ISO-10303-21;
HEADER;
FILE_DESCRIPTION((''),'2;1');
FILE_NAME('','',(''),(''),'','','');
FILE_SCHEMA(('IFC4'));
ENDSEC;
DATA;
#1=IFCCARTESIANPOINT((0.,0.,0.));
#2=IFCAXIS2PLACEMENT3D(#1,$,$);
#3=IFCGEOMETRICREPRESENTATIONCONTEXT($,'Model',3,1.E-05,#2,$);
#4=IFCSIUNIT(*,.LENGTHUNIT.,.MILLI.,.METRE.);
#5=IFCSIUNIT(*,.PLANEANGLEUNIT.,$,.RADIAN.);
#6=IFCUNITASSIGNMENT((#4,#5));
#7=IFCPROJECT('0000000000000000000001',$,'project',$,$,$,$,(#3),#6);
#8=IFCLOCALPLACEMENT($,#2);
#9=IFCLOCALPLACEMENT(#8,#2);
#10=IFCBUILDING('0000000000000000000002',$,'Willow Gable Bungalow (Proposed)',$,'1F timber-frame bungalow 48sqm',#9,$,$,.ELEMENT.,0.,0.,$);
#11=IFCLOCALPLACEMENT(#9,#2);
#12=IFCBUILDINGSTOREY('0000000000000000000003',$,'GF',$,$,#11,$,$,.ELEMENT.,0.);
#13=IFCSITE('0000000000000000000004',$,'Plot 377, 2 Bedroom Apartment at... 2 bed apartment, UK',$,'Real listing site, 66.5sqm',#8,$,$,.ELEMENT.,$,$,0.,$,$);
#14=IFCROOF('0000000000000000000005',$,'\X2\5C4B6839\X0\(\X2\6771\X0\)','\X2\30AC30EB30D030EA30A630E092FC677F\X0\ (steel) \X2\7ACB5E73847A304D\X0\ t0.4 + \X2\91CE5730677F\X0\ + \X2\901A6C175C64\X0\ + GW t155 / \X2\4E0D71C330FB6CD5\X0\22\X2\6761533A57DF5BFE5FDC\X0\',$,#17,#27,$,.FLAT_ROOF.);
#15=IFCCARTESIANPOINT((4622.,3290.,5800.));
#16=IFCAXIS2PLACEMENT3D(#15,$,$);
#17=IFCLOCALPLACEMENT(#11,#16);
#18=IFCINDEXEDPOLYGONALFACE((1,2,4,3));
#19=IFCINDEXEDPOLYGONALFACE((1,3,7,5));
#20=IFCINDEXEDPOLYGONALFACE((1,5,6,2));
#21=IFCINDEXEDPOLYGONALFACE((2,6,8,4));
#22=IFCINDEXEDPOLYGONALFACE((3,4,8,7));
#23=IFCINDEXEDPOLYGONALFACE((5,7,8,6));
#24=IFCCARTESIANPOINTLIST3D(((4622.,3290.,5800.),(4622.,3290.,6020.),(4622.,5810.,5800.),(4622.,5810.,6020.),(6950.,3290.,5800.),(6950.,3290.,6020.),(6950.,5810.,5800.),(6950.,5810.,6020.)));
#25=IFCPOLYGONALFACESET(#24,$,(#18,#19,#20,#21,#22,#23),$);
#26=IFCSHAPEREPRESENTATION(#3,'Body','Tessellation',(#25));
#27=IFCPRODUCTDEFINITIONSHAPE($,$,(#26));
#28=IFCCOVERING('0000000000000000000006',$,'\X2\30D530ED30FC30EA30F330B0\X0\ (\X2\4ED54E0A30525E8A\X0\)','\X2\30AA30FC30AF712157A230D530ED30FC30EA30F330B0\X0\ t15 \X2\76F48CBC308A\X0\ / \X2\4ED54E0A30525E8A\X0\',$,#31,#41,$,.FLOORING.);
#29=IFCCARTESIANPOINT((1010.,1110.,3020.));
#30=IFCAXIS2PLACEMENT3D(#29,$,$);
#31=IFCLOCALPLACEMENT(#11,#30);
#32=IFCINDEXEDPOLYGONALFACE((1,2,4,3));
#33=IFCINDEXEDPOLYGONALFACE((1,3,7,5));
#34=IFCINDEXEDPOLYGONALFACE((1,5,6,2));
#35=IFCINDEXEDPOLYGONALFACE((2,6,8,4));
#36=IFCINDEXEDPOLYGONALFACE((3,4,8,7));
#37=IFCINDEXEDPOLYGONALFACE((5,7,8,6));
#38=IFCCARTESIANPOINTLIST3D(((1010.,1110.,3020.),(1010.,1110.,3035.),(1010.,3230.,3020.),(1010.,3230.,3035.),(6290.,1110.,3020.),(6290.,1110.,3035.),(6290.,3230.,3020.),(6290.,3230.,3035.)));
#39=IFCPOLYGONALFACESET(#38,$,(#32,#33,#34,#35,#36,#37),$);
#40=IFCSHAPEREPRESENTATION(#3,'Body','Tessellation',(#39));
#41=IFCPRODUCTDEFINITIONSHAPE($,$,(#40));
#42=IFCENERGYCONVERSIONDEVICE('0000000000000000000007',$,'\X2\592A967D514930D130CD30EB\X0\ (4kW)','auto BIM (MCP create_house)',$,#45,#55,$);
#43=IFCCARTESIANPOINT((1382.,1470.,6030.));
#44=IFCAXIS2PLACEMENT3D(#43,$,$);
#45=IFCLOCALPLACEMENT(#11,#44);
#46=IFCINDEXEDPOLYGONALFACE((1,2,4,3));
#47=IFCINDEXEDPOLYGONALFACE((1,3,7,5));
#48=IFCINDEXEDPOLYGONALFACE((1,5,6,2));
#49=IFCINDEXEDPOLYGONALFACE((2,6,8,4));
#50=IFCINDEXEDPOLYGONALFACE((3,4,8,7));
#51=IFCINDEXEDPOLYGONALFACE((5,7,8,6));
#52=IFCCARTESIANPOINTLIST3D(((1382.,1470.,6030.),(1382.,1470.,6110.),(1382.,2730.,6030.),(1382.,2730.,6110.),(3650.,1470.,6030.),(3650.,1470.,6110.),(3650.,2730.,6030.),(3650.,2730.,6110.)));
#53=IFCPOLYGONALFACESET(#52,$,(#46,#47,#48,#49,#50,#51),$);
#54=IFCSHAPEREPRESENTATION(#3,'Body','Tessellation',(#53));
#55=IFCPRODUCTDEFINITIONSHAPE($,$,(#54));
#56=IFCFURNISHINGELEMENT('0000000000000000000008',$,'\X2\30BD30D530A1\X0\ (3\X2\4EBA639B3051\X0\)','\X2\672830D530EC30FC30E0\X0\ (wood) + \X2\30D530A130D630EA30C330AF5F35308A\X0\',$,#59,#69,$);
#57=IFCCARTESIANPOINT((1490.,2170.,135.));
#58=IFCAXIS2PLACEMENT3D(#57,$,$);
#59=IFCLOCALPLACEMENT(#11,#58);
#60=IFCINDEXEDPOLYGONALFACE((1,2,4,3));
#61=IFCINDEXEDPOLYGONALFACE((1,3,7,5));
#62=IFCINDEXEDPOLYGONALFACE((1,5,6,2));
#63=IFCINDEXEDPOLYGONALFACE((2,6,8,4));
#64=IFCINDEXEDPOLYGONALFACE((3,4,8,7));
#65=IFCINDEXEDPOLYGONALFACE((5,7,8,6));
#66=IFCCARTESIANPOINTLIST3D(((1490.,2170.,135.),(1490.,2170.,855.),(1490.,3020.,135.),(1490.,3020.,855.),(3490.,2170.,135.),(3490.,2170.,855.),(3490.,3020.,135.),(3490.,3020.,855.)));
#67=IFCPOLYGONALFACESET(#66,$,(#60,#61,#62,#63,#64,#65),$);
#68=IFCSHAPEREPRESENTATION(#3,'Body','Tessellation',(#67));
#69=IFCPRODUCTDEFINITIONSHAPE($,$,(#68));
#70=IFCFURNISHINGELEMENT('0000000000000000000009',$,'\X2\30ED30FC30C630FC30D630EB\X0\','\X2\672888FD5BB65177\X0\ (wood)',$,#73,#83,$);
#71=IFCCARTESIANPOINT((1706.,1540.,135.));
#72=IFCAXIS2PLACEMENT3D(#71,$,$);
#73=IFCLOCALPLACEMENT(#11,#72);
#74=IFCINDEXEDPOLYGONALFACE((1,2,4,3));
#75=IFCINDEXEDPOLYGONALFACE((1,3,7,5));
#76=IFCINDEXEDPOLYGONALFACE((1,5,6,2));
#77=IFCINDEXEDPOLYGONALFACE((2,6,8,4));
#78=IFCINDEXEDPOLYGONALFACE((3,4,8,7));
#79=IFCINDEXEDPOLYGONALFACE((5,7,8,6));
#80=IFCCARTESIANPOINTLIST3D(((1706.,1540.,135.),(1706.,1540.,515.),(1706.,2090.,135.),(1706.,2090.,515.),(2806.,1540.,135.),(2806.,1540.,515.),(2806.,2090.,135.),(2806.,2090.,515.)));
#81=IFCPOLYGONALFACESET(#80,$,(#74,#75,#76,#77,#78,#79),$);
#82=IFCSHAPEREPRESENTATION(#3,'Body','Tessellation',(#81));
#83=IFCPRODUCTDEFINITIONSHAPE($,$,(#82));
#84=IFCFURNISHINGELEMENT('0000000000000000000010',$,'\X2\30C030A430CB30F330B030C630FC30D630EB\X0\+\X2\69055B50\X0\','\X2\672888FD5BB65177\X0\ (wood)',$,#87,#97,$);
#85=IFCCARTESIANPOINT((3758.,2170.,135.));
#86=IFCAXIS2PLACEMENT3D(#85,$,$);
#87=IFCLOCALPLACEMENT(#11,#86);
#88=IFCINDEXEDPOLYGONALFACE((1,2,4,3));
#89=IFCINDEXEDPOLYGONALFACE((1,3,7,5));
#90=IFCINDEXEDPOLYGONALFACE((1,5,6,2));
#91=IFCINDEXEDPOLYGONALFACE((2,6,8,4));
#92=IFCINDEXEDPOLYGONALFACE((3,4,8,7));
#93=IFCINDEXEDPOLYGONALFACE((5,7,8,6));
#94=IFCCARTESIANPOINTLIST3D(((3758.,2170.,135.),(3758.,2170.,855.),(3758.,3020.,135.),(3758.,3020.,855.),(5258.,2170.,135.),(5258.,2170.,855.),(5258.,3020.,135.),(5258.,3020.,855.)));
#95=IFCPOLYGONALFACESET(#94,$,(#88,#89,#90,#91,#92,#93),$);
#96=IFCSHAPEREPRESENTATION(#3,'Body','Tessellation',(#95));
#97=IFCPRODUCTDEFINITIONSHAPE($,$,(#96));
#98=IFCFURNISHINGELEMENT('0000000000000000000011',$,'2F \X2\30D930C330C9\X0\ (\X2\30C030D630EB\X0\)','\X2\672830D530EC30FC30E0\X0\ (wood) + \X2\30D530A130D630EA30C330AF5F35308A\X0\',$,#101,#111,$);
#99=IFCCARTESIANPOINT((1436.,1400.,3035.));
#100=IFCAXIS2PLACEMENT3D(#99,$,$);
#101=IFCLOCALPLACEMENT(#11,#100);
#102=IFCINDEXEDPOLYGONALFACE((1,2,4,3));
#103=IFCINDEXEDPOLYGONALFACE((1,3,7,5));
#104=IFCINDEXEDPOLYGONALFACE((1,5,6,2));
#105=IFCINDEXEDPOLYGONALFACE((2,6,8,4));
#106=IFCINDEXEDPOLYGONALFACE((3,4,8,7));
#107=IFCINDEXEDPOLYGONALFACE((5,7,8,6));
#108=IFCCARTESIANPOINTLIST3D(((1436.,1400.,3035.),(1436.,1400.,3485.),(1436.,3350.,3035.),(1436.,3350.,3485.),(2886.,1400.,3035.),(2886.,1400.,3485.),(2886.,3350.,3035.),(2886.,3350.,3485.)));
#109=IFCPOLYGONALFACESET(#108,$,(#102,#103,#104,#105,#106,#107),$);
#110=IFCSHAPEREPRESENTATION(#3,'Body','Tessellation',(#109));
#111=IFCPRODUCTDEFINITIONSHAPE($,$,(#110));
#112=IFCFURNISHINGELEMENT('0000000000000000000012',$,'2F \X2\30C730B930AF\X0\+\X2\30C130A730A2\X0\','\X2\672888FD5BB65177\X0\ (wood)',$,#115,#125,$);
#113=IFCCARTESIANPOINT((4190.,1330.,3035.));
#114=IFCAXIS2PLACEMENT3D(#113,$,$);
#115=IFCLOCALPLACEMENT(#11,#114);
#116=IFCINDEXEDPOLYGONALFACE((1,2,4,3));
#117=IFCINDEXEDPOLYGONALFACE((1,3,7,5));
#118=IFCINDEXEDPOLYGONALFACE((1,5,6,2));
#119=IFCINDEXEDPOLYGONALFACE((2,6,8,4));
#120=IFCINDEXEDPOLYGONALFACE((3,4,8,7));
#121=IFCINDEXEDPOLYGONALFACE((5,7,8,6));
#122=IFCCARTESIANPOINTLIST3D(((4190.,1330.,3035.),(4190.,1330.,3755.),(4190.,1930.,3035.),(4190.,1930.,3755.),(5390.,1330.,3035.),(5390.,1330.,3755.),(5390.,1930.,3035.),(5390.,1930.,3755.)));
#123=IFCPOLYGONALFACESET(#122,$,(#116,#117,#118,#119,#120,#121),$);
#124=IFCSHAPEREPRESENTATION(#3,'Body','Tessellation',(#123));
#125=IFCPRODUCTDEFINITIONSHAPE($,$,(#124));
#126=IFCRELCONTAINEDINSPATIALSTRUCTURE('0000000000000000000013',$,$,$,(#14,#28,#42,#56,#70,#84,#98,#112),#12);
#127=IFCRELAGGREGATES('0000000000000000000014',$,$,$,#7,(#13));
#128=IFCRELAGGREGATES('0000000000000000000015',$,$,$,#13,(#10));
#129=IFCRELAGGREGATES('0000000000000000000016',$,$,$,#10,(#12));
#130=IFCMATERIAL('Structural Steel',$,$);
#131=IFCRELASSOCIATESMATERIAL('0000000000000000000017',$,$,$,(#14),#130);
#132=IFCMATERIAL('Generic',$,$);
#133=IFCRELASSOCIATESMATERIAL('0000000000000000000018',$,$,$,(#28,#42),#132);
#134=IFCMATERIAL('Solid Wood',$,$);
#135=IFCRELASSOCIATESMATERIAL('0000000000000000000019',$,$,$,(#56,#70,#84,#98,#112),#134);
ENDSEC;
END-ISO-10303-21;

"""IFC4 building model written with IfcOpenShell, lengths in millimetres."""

from ifc_helpers import new_model, si_unit, frame, frame_2d, origin, place, context, project, spatial, rectangle, extrude, material, element, save


model = new_model("IFC4")

# Units and contexts
model_context = context("Model", 3, precision=1e-05, world=origin())
ifc_project = project(units=[si_unit("LENGTHUNIT", "METRE", prefix="MILLI"), si_unit("PLANEANGLEUNIT", "RADIAN")], contexts=[model_context])

# Site, building, storey
site_placement = place(None, origin())
site = spatial("IfcSite", under=ifc_project, at=site_placement, Name="Plot 377, 2 Bedroom Apartment at... 2 bed apartment, UK", ObjectType="Real listing site, 66.5sqm", CompositionType="ELEMENT", RefElevation=0.0)
building_placement = place(site_placement, origin())
building = spatial("IfcBuilding", under=site, at=building_placement, Name="Willow Gable Bungalow (Proposed)", ObjectType="1F timber-frame bungalow 48sqm", CompositionType="ELEMENT", ElevationOfRefHeight=0.0, ElevationOfTerrain=0.0)
storey_placement = place(building_placement, origin())
storey = spatial("IfcBuildingStorey", under=building, at=storey_placement, Name="GF", CompositionType="ELEMENT", Elevation=0.0)

# Shared definitions
ifc_material_1 = material(Name="Solid Wood")

# Roof
ifc_material_2 = material(Name="Structural Steel")
roof_1_placement = place(storey_placement, frame((4622.0, 3290.0, 5800.0)))
element("IfcRoof", 1, at=roof_1_placement, inside=storey, material=ifc_material_2, Name="屋根(東)", Description="ガルバリウム鋼板 (steel) 立平葺き t0.4 + 野地板 + 通気層 + GW t155 / 不燃・法22条区域対応", PredefinedType="FLAT_ROOF", context=model_context, shape_type="SweptSolid", body=[
    extrude(rectangle(XDim=2328.0, YDim=2520.0, at=frame_2d((1164.0, 1260.0))), frame((4622.0, 3290.0, 5800.0)), (0.0, 0.0, 1.0), 220.0),
])

# Covering
ifc_material_3 = material(Name="Generic")
covering_placement = place(storey_placement, frame((1010.0, 1110.0, 3020.0)))
element("IfcCovering", 2, at=covering_placement, inside=storey, material=ifc_material_3, Name="フローリング (仕上げ床)", Description="オーク無垢フローリング t15 直貼り / 仕上げ床", PredefinedType="FLOORING", context=model_context, shape_type="SweptSolid", body=[
    extrude(rectangle(XDim=5280.0, YDim=2120.0, at=frame_2d((2640.0, 1060.0))), frame((1010.0, 1110.0, 3020.0)), (0.0, 0.0, 1.0), 15.0),
])

# Energy conversion device
energy_conversion_device_placement = place(storey_placement, frame((1382.0, 1470.0, 6030.0)))
element("IfcEnergyConversionDevice", 3, at=energy_conversion_device_placement, inside=storey, material=ifc_material_3, Name="太陽光パネル (4kW)", Description="auto BIM (MCP create_house)", context=model_context, shape_type="SweptSolid", body=[
    extrude(rectangle(XDim=2268.0, YDim=1260.0, at=frame_2d((1134.0, 630.0))), frame((1382.0, 1470.0, 6030.0)), (0.0, 0.0, 1.0), 80.0),
])

# Furnishing elements
furnishing_1_placement = place(storey_placement, frame((1490.0, 2170.0, 135.0)))
element("IfcFurnishingElement", 4, at=furnishing_1_placement, inside=storey, material=ifc_material_1, Name="ソファ (3人掛け)", Description="木フレーム (wood) + ファブリック張り", context=model_context, shape_type="SweptSolid", body=[
    extrude(rectangle(XDim=2000.0, YDim=850.0, at=frame_2d((1000.0, 425.0))), frame((1490.0, 2170.0, 135.0)), (0.0, 0.0, 1.0), 720.0),
])
furnishing_2_placement = place(storey_placement, frame((1706.0, 1540.0, 135.0)))
element("IfcFurnishingElement", 5, at=furnishing_2_placement, inside=storey, material=ifc_material_1, Name="ローテーブル", Description="木製家具 (wood)", context=model_context, shape_type="SweptSolid", body=[
    extrude(rectangle(XDim=1100.0, YDim=550.0, at=frame_2d((550.0, 275.0))), frame((1706.0, 1540.0, 135.0)), (0.0, 0.0, 1.0), 380.0),
])
furnishing_3_placement = place(storey_placement, frame((3758.0, 2170.0, 135.0)))
element("IfcFurnishingElement", 6, at=furnishing_3_placement, inside=storey, material=ifc_material_1, Name="ダイニングテーブル+椅子", Description="木製家具 (wood)", context=model_context, shape_type="SweptSolid", body=[
    extrude(rectangle(XDim=1500.0, YDim=850.0, at=frame_2d((750.0, 425.0))), frame((3758.0, 2170.0, 135.0)), (0.0, 0.0, 1.0), 720.0),
])
furnishing_4_placement = place(storey_placement, frame((1436.0, 1400.0, 3035.0)))
element("IfcFurnishingElement", 7, at=furnishing_4_placement, inside=storey, material=ifc_material_1, Name="2F ベッド (ダブル)", Description="木フレーム (wood) + ファブリック張り", context=model_context, shape_type="SweptSolid", body=[
    extrude(rectangle(XDim=1450.0, YDim=1950.0, at=frame_2d((725.0, 975.0))), frame((1436.0, 1400.0, 3035.0)), (0.0, 0.0, 1.0), 450.0),
])
furnishing_5_placement = place(storey_placement, frame((4190.0, 1330.0, 3035.0)))
element("IfcFurnishingElement", 8, at=furnishing_5_placement, inside=storey, material=ifc_material_1, Name="2F デスク+チェア", Description="木製家具 (wood)", context=model_context, shape_type="SweptSolid", body=[
    extrude(rectangle(XDim=1200.0, YDim=600.0, at=frame_2d((600.0, 300.0))), frame((4190.0, 1330.0, 3035.0)), (0.0, 0.0, 1.0), 720.0),
])

save(model, "model.ifc")
